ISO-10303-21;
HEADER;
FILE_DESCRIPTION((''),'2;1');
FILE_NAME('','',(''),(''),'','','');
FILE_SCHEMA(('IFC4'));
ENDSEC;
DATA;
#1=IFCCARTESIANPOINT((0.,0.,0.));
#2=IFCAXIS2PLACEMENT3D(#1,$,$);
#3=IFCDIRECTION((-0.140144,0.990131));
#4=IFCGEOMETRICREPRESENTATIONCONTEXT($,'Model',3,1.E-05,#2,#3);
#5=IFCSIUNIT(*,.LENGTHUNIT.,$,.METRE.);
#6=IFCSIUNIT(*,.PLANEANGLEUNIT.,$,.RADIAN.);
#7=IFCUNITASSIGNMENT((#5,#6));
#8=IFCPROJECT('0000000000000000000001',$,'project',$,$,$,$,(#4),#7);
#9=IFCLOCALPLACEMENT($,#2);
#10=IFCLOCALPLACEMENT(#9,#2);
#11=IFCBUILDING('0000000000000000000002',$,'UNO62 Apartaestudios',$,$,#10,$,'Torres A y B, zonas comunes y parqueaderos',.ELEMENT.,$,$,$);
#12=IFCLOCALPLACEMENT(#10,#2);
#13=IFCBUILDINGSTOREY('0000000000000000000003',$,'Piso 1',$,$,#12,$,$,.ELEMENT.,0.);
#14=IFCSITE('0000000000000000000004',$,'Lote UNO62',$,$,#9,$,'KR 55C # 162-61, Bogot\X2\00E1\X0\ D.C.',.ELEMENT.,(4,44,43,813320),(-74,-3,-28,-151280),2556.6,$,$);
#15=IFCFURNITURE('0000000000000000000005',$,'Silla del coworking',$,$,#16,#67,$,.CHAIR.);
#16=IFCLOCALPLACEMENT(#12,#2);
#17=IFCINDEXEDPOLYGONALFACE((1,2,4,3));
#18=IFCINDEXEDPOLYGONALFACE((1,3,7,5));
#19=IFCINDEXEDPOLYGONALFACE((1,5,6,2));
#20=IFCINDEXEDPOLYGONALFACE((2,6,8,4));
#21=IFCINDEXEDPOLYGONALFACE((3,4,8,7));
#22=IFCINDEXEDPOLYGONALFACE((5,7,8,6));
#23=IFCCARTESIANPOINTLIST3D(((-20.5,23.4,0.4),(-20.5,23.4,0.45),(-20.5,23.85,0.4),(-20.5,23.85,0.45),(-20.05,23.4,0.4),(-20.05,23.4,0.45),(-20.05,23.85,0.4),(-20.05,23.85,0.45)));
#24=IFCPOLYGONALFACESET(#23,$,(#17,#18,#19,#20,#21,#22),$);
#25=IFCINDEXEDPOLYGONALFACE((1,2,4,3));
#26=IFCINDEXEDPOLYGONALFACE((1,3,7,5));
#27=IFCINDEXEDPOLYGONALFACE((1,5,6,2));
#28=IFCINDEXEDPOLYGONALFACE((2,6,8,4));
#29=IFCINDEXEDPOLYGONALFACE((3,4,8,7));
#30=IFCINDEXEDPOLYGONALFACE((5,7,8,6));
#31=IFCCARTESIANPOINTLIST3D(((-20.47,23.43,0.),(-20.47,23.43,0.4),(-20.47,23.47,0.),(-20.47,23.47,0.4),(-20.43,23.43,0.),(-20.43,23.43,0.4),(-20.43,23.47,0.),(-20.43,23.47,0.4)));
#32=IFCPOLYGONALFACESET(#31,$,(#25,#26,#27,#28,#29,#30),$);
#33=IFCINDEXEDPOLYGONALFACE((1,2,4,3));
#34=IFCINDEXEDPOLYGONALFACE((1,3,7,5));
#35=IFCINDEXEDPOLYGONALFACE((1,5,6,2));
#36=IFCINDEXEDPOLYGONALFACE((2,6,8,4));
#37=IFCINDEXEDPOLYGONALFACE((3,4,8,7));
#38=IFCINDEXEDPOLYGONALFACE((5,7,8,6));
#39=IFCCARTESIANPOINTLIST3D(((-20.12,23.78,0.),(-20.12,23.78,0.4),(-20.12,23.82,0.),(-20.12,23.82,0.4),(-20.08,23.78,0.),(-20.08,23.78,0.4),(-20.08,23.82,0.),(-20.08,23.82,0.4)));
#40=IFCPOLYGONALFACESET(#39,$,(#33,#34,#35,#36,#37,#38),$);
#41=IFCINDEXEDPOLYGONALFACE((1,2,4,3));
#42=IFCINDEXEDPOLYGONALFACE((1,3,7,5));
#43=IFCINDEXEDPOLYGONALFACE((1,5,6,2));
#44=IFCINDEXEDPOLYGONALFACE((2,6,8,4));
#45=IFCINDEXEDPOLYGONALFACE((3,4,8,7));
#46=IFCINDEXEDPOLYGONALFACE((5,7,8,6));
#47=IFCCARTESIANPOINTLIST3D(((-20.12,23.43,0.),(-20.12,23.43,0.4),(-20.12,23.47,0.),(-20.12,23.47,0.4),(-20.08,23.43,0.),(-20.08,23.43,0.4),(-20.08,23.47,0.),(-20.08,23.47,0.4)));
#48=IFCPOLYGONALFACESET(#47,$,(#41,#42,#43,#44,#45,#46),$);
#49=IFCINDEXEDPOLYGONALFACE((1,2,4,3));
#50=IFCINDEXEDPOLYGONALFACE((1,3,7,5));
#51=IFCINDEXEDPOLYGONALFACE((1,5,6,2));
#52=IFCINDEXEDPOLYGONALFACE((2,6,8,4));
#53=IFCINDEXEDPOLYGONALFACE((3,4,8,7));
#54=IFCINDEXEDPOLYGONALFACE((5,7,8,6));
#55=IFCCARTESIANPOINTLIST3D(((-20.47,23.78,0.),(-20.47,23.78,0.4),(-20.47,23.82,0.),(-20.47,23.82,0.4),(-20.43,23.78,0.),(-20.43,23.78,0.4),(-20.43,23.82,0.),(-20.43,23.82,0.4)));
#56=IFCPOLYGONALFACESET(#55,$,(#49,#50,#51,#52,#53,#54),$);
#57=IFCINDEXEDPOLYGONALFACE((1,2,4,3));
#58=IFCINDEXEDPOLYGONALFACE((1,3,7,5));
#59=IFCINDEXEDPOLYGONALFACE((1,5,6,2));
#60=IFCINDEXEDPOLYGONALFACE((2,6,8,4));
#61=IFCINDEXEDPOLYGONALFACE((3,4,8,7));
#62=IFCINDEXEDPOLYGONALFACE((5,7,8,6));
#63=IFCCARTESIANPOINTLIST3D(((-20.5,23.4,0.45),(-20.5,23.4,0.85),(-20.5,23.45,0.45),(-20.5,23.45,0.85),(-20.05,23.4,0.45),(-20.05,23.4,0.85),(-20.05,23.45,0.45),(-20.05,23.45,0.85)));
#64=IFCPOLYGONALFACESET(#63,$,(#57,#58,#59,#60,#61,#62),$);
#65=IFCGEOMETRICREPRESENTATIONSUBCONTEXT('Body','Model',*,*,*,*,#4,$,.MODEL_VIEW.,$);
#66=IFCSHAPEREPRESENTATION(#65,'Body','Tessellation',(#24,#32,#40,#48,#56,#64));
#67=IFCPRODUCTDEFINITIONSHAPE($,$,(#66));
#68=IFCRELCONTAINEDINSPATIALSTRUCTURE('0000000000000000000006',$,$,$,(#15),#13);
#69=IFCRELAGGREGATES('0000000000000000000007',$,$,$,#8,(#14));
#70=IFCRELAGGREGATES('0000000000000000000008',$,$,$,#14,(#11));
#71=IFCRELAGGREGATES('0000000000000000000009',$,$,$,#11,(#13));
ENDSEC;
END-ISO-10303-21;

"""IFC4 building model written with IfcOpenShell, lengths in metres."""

from ifc_helpers import new_model, si_unit, direction, frame, frame_2d, origin, place, context, subcontext, project, spatial, rectangle, extrude, element, save


model = new_model("IFC4")

# Units and contexts
model_context = context("Model", 3, precision=1e-05, world=origin(), true_north=direction((-0.140144, 0.990131)))
body_context = subcontext(model_context, "Body", "Model", "MODEL_VIEW")
ifc_project = project(units=[si_unit("LENGTHUNIT", "METRE"), si_unit("PLANEANGLEUNIT", "RADIAN")], contexts=[model_context])

# Site, building, storey
site_placement = place(None, origin())
site = spatial("IfcSite", under=ifc_project, at=site_placement, Name="Lote UNO62", LongName="KR 55C # 162-61, Bogotá D.C.", CompositionType="ELEMENT", RefLatitude=(4, 44, 43, 813320), RefLongitude=(-74, -3, -28, -151280), RefElevation=2556.6)
building_placement = place(site_placement, origin())
building = spatial("IfcBuilding", under=site, at=building_placement, Name="UNO62 Apartaestudios", LongName="Torres A y B, zonas comunes y parqueaderos", CompositionType="ELEMENT")
storey_placement = place(building_placement, origin())
storey = spatial("IfcBuildingStorey", under=building, at=storey_placement, Name="Piso 1", CompositionType="ELEMENT", Elevation=0.0)

# Furniture
furniture_1_placement = place(storey_placement, origin())
element("IfcFurniture", 1, at=furniture_1_placement, inside=storey, Name="Silla del coworking", PredefinedType="CHAIR", context=body_context, shape_type="SweptSolid", body=[
    extrude(rectangle(XDim=0.45, YDim=0.45, at=frame_2d((-20.275, 23.625))), frame((0.0, 0.0, 0.4)), (0.0, 0.0, 1.0), 0.05),
    extrude(rectangle(XDim=0.04, YDim=0.04, at=frame_2d((-20.45, 23.45))), origin(), (0.0, 0.0, 1.0), 0.4),
    extrude(rectangle(XDim=0.04, YDim=0.04, at=frame_2d((-20.1, 23.8))), origin(), (0.0, 0.0, 1.0), 0.4),
    extrude(rectangle(XDim=0.04, YDim=0.04, at=frame_2d((-20.1, 23.45))), origin(), (0.0, 0.0, 1.0), 0.4),
    extrude(rectangle(XDim=0.04, YDim=0.04, at=frame_2d((-20.45, 23.8))), origin(), (0.0, 0.0, 1.0), 0.4),
    extrude(rectangle(XDim=0.45, YDim=0.05, at=frame_2d((-20.275, 23.425))), frame((0.0, 0.0, 0.45)), (0.0, 0.0, 1.0), 0.4),
])

save(model, "model.ifc")
